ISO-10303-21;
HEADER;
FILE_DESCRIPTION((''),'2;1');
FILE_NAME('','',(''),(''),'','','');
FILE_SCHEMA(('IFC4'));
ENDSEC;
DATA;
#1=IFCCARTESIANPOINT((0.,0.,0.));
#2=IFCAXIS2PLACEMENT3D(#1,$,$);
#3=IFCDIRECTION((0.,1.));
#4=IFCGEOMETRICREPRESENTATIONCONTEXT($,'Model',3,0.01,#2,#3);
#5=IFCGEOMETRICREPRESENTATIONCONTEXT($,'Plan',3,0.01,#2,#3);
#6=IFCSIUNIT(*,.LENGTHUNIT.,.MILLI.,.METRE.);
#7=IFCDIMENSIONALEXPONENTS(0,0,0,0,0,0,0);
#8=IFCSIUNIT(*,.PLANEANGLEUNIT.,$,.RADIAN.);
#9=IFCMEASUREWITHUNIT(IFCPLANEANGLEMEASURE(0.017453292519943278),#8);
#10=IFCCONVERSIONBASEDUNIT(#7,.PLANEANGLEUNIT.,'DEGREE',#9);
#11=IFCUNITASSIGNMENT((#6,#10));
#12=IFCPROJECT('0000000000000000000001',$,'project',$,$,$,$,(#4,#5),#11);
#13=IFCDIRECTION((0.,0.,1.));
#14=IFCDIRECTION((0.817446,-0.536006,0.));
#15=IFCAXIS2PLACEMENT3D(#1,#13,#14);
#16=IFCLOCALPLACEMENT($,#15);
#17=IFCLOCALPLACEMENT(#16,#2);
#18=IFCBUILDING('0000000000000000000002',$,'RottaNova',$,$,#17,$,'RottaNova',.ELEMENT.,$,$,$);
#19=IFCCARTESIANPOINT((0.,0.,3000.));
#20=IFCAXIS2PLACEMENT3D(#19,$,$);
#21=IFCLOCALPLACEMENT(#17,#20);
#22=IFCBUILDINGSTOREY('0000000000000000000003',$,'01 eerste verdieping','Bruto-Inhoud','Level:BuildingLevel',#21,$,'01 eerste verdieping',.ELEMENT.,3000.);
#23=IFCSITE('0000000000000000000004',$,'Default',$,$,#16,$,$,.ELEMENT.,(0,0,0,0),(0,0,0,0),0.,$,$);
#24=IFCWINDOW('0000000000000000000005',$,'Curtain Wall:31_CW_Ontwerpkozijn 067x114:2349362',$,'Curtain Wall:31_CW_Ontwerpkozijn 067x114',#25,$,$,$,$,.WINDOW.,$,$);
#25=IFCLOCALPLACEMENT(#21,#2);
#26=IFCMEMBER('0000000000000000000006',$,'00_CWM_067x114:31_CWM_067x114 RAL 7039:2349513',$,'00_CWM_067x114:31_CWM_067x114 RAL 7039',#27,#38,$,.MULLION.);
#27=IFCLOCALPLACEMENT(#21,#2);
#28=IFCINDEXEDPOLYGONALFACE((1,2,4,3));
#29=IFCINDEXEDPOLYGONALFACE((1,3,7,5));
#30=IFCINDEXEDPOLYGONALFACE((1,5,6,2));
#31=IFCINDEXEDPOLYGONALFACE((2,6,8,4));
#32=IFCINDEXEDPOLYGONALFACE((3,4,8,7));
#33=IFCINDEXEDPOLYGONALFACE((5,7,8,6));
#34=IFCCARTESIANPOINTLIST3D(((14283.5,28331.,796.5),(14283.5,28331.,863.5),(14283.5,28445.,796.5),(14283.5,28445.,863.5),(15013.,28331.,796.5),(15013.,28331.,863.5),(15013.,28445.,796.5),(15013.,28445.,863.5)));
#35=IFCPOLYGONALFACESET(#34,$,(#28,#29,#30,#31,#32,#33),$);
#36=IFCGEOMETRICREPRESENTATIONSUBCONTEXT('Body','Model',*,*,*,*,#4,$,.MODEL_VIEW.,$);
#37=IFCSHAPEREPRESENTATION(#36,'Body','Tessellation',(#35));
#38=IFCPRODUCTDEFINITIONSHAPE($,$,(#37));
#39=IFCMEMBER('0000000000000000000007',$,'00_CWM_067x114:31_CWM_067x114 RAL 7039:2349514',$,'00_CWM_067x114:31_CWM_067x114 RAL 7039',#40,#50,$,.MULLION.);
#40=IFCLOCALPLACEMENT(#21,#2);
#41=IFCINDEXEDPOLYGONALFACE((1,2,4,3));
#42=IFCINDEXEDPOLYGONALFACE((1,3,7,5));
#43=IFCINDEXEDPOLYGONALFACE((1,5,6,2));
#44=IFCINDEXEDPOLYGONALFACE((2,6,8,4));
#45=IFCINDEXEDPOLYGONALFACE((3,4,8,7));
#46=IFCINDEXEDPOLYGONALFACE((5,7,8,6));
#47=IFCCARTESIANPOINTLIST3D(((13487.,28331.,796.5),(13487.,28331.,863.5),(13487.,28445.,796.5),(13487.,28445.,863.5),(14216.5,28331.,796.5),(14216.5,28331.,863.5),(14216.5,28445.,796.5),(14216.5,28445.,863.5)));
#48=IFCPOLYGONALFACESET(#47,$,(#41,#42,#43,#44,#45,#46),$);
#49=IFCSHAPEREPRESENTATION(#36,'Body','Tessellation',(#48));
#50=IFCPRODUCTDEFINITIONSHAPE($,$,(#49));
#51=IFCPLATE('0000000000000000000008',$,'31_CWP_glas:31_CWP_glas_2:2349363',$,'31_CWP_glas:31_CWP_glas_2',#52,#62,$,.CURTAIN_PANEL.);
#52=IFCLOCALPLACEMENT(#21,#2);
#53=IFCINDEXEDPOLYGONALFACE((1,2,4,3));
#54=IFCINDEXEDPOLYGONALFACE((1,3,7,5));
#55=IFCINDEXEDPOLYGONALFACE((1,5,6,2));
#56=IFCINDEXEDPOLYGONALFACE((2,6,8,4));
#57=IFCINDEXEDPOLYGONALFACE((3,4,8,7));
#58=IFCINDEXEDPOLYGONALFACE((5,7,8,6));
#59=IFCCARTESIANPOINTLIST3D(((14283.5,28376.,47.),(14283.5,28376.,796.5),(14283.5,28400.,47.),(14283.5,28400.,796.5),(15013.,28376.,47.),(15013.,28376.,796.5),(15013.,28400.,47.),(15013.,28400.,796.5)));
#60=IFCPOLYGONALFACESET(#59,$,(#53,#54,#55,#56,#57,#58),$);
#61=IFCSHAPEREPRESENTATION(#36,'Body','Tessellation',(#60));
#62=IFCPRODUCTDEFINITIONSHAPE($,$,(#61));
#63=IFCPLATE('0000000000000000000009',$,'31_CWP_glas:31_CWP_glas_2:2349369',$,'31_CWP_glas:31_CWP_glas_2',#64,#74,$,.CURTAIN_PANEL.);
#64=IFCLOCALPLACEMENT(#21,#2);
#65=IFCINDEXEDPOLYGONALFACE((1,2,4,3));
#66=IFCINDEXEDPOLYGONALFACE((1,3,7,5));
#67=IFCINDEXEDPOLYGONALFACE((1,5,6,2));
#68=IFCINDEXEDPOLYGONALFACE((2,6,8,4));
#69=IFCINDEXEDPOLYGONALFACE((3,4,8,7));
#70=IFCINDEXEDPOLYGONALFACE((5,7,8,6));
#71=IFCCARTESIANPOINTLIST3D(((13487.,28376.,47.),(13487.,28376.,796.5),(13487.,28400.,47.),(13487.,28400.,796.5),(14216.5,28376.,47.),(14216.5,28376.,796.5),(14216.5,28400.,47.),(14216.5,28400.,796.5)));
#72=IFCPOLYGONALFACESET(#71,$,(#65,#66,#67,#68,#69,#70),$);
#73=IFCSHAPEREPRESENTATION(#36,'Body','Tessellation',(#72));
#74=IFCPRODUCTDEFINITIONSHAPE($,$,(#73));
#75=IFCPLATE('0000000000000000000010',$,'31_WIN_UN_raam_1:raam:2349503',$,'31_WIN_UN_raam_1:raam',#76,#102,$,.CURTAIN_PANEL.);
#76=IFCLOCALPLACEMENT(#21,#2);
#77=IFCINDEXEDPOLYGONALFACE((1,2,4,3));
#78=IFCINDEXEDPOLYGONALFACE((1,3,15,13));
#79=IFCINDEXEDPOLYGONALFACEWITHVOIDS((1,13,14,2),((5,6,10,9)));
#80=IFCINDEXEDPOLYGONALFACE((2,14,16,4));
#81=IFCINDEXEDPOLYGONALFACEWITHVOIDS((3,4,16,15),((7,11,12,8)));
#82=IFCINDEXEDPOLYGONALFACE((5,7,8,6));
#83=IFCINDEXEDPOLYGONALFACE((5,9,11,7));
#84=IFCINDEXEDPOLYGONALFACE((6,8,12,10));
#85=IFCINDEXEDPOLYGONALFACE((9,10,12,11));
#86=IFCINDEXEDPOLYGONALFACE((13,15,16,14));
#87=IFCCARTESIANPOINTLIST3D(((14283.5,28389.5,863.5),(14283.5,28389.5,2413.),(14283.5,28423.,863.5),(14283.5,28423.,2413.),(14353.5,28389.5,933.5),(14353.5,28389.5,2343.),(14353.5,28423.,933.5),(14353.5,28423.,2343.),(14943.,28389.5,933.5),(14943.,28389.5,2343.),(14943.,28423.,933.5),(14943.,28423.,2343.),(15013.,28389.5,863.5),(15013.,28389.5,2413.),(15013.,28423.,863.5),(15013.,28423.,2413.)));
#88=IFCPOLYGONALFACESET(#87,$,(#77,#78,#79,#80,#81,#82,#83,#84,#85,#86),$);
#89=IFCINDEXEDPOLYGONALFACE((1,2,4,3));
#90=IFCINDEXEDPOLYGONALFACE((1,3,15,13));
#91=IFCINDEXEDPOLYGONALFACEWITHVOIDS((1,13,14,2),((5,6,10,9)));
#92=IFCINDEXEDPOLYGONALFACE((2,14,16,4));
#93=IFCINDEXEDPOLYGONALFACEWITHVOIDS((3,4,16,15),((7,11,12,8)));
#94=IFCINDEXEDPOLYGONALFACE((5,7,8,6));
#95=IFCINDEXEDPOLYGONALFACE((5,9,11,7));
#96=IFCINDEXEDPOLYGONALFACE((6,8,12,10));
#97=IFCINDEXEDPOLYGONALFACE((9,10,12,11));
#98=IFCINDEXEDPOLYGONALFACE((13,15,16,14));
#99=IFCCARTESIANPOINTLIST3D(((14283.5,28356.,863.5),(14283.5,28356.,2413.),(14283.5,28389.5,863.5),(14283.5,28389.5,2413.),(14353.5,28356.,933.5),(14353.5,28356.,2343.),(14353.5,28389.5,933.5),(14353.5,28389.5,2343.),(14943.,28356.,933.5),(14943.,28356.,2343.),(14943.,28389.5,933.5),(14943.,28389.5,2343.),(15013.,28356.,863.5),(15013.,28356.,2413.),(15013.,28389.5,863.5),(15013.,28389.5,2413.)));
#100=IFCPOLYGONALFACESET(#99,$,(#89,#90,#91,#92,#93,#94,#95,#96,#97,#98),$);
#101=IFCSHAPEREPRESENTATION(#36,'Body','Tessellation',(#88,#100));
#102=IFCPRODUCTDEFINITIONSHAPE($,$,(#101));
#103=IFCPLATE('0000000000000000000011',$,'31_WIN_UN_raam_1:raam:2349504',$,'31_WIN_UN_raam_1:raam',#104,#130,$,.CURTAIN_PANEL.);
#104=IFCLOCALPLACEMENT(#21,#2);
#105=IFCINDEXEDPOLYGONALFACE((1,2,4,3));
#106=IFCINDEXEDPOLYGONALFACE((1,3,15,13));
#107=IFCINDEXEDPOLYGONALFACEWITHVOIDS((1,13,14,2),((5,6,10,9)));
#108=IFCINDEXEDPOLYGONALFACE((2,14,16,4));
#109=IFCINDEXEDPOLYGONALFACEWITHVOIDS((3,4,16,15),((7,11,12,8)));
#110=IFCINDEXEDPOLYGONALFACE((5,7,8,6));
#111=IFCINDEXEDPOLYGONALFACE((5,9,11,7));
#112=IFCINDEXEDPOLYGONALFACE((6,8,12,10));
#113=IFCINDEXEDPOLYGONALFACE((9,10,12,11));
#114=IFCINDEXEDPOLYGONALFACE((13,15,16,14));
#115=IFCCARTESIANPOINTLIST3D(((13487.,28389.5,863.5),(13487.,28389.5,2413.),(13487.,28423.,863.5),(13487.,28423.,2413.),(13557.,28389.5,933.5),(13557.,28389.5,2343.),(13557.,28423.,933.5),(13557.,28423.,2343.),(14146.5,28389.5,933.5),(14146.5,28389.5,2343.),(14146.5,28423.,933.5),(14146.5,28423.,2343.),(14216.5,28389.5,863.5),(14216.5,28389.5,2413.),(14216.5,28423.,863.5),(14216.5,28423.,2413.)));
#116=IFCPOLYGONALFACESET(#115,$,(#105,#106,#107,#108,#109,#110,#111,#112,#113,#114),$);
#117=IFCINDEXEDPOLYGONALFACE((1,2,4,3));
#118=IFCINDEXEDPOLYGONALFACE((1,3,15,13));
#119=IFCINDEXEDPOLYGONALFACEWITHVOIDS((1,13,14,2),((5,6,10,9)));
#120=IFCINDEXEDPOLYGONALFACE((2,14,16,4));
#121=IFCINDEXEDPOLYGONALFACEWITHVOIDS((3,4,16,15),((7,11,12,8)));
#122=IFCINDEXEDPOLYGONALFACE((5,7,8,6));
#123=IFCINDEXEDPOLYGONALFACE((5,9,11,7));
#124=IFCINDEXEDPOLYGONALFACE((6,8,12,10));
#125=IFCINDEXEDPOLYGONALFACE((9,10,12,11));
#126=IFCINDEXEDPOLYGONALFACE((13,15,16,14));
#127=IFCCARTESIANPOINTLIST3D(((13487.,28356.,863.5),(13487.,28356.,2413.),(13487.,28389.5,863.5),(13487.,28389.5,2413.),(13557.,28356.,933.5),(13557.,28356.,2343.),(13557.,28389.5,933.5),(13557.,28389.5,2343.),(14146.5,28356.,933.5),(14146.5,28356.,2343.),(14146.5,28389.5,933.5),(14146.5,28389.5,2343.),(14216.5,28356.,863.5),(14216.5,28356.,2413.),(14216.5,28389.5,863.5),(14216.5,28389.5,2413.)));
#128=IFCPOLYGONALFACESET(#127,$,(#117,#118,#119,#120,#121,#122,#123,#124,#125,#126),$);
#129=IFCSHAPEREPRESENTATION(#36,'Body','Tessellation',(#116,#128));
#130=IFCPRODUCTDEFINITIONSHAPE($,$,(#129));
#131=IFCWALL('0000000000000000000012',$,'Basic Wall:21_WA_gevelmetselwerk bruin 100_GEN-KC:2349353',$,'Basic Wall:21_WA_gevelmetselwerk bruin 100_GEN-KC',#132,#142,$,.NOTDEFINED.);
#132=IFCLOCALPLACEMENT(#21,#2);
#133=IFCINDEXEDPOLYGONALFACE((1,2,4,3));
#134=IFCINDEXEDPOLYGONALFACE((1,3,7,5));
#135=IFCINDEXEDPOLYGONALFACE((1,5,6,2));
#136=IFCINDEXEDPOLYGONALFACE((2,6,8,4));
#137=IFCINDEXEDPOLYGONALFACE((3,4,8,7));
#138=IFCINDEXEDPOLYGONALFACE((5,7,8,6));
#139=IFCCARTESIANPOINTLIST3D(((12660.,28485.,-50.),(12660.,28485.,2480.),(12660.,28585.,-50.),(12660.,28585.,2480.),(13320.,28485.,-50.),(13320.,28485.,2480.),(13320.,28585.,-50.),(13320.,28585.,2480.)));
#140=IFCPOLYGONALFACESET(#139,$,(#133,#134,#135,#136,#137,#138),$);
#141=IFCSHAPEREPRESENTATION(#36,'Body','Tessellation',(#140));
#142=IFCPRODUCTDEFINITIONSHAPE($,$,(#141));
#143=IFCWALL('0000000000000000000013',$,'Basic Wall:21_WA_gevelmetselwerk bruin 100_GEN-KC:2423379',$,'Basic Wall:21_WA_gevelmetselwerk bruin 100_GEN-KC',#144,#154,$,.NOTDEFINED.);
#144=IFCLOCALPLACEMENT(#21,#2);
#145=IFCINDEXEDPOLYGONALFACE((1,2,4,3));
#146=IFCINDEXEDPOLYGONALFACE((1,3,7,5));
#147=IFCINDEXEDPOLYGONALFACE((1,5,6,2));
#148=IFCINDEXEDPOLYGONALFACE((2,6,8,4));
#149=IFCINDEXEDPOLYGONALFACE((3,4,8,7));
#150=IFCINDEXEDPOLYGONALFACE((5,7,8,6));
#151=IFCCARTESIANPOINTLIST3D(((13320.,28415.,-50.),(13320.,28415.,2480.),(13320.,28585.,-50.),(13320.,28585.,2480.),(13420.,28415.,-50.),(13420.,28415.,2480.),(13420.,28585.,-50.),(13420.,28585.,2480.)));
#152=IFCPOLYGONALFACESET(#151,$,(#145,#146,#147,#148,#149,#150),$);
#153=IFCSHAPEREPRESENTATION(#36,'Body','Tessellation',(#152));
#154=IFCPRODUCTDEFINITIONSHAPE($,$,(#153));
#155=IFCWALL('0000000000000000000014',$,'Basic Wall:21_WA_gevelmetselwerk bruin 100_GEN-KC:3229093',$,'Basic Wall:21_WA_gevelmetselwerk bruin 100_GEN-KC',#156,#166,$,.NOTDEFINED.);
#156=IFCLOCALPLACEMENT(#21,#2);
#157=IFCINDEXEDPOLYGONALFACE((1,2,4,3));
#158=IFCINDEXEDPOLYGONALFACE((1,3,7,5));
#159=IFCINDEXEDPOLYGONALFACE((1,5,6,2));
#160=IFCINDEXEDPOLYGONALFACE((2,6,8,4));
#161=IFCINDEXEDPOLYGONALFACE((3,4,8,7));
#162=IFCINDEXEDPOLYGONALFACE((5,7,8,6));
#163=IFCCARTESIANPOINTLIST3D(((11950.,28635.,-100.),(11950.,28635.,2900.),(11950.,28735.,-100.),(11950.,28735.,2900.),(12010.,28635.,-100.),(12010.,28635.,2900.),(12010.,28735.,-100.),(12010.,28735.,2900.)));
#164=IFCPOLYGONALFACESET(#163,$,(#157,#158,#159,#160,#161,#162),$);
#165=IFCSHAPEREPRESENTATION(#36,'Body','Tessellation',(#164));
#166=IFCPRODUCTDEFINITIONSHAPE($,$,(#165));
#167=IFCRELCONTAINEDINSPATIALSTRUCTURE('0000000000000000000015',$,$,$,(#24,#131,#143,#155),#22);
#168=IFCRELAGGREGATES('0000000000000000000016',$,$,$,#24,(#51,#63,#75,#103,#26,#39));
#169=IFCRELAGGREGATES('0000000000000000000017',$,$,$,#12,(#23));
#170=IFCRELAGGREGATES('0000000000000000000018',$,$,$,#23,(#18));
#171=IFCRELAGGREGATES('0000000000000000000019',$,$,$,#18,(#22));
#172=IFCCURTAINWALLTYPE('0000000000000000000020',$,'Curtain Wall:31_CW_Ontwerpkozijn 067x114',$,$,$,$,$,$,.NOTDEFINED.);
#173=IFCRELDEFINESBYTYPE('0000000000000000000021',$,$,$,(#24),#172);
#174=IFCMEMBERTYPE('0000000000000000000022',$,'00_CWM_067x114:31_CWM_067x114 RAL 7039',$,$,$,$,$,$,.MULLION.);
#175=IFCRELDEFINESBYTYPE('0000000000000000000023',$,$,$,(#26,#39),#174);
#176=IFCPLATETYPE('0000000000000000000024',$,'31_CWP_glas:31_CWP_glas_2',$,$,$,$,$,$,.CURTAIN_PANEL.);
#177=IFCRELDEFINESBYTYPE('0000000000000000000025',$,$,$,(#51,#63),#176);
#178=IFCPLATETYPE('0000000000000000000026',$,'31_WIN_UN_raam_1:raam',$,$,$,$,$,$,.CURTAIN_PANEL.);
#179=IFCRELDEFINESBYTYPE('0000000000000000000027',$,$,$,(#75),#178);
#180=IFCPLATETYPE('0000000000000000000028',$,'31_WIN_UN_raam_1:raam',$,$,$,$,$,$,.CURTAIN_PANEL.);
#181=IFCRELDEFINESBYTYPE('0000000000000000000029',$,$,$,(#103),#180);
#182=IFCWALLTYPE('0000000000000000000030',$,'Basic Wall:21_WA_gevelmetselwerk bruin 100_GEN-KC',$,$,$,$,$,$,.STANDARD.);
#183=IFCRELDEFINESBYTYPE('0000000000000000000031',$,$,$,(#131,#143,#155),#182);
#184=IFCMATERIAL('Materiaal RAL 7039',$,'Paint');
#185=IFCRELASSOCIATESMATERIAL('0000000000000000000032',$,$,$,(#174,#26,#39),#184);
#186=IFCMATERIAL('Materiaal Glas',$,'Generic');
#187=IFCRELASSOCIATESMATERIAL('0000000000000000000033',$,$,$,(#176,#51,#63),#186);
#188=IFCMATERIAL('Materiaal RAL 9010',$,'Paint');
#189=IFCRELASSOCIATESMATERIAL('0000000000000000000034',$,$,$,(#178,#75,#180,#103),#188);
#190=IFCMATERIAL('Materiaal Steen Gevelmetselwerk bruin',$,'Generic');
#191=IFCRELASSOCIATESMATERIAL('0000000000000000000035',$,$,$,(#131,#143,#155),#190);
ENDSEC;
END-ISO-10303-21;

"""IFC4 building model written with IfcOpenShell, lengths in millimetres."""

from ifc_helpers import new_model, entity, si_unit, converted_unit, direction, frame, origin, place, context, subcontext, project, spatial, indexed_curve, outline, extrude, source, transform, mapped, material, type_object, type_shapes, element, aggregate, save


model = new_model("IFC4")

# Units and contexts
model_context = context("Model", 3, precision=0.01, world=origin(), true_north=direction((0.0, 1.0)))
plan_context = context("Plan", 3, precision=0.01, world=origin(), true_north=direction((0.0, 1.0)))
body_context = subcontext(model_context, "Body", "Model", "MODEL_VIEW")
ifc_project = project(units=[si_unit("LENGTHUNIT", "METRE", prefix="MILLI"), converted_unit("PLANEANGLEUNIT", "DEGREE", entity("IfcPlaneAngleMeasure", 0.017453292519943278), si_unit("PLANEANGLEUNIT", "RADIAN"), dimensions=[0, 0, 0, 0, 0, 0, 0])], contexts=[model_context, plan_context])

# Site, building, storey
site_placement = place(None, frame((0.0, 0.0, 0.0), z_axis=(0.0, 0.0, 1.0), x_axis=(0.817446, -0.536006, 0.0)))
site = spatial("IfcSite", under=ifc_project, at=site_placement, Name="Default", CompositionType="ELEMENT", RefLatitude=(0, 0, 0, 0), RefLongitude=(0, 0, 0, 0), RefElevation=0.0)
building_placement = place(site_placement, origin())
building = spatial("IfcBuilding", under=site, at=building_placement, Name="RottaNova", LongName="RottaNova", CompositionType="ELEMENT")
storey_placement = place(building_placement, frame((0.0, 0.0, 3000.0)))
storey = spatial("IfcBuildingStorey", under=building, at=storey_placement, Name="01 eerste verdieping", Description="Bruto-Inhoud", ObjectType="Level:BuildingLevel", LongName="01 eerste verdieping", CompositionType="ELEMENT", Elevation=3000.0)

# Window, members, plates
curtain_wall_type = type_object("IfcCurtainWallType", Name="Curtain Wall:31_CW_Ontwerpkozijn 067x114", PredefinedType="NOTDEFINED")
window_placement = place(storey_placement, frame((0.0, 0.0, -3000.0)))
window = element("IfcWindow", 1, at=window_placement, inside=storey, type_object=curtain_wall_type, Name="Curtain Wall:31_CW_Ontwerpkozijn 067x114:2349362", ObjectType="Curtain Wall:31_CW_Ontwerpkozijn 067x114", PredefinedType="WINDOW")
ifc_material_1 = material(Name="Materiaal RAL 7039", Category="Paint")
member_type_1 = type_object("IfcMemberType", Name="00_CWM_067x114:31_CWM_067x114 RAL 7039", PredefinedType="MULLION", material=ifc_material_1)
shared_shape_1 = source(origin(), body_context, "Body", "SweptSolid", [
    extrude(outline(indexed_curve([(-33.5, -57.0), (33.5, -57.0), (33.5, 57.0), (-33.5, 57.0), (-33.5, -57.0)], self_intersect=False)), frame((0.0, 57.0, -729.5), z_axis=(0.0, 0.0, 1.0), x_axis=(-1.0, 0.0, 0.0)), (0.0, 0.0, 1.0), 729.5),
])
type_shapes(member_type_1, [shared_shape_1])
member_1_placement = place(window_placement, frame((14283.5, 28331.0, 3830.0), z_axis=(-1.0, 0.0, 0.0), x_axis=(0.0, 0.0, 1.0)))
member_1 = element("IfcMember", 2, at=member_1_placement, type_object=member_type_1, material=ifc_material_1, Name="00_CWM_067x114:31_CWM_067x114 RAL 7039:2349513", ObjectType="00_CWM_067x114:31_CWM_067x114 RAL 7039", PredefinedType="MULLION", context=body_context, shape_type="MappedRepresentation", body=[
    mapped(shared_shape_1, transform((0.0, 0.0, 0.0), scale=1.0)),
])
member_2_placement = place(window_placement, frame((13487.0, 28331.0, 3830.0), z_axis=(-1.0, 0.0, 0.0), x_axis=(0.0, 0.0, 1.0)))
member_2 = element("IfcMember", 3, at=member_2_placement, type_object=member_type_1, material=ifc_material_1, Name="00_CWM_067x114:31_CWM_067x114 RAL 7039:2349514", ObjectType="00_CWM_067x114:31_CWM_067x114 RAL 7039", PredefinedType="MULLION", context=body_context, shape_type="MappedRepresentation", body=[
    mapped(shared_shape_1, transform((0.0, 0.0, 0.0), scale=1.0)),
])
ifc_material_2 = material(Name="Materiaal Glas", Category="Generic")
plate_type_1 = type_object("IfcPlateType", Name="31_CWP_glas:31_CWP_glas_2", PredefinedType="CURTAIN_PANEL", material=ifc_material_2)
shared_shape_2 = source(origin(), body_context, "Body", "SweptSolid", [
    extrude(outline(indexed_curve([(-12.0, -364.7), (12.0, -364.7), (12.0, 364.7), (-12.0, 364.7), (-12.0, -364.7)], self_intersect=False)), frame((0.0, -57.0, 0.0), z_axis=(0.0, 0.0, 1.0), x_axis=(0.0, 1.0, 0.0)), (0.0, 0.0, 1.0), 749.5),
])
type_shapes(plate_type_1, [shared_shape_2])
plate_1_placement = place(window_placement, frame((14648.3, 28331.0, 3047.0), z_axis=(0.0, 0.0, 1.0), x_axis=(-1.0, 0.0, 0.0)))
plate_1 = element("IfcPlate", 4, at=plate_1_placement, type_object=plate_type_1, material=ifc_material_2, Name="31_CWP_glas:31_CWP_glas_2:2349363", ObjectType="31_CWP_glas:31_CWP_glas_2", PredefinedType="CURTAIN_PANEL", context=body_context, shape_type="MappedRepresentation", body=[
    mapped(shared_shape_2, transform((0.0, 0.0, 0.0), scale=1.0)),
])
plate_2_placement = place(window_placement, frame((13851.8, 28331.0, 3047.0), z_axis=(0.0, 0.0, 1.0), x_axis=(-1.0, 0.0, 0.0)))
plate_2 = element("IfcPlate", 5, at=plate_2_placement, type_object=plate_type_1, material=ifc_material_2, Name="31_CWP_glas:31_CWP_glas_2:2349369", ObjectType="31_CWP_glas:31_CWP_glas_2", PredefinedType="CURTAIN_PANEL", context=body_context, shape_type="MappedRepresentation", body=[
    mapped(shared_shape_2, transform((0.0, 0.0, 0.0), scale=1.0)),
])
ifc_material_3 = material(Name="Materiaal RAL 9010", Category="Paint")
plate_type_2 = type_object("IfcPlateType", Name="31_WIN_UN_raam_1:raam", PredefinedType="CURTAIN_PANEL", material=ifc_material_3)
shared_shape_3 = source(origin(), body_context, "Body", "SweptSolid", [
    extrude(outline(indexed_curve([(-364.7, -774.7), (364.7, -774.7), (364.7, 774.7), (-364.7, 774.7), (-364.7, -774.7)], self_intersect=False), holes=[indexed_curve([(-294.7, 704.7), (294.7, 704.7), (294.7, -704.8), (-294.7, -704.8), (-294.7, 704.7)], self_intersect=False)]), frame((0.0, -92.0, 774.8), z_axis=(0.0, 1.0, 0.0), x_axis=(1.0, 0.0, 0.0)), (0.0, 0.0, 1.0), 33.5),
    extrude(outline(indexed_curve([(-364.7, -774.7), (364.7, -774.7), (364.7, 774.7), (-364.7, 774.7), (-364.7, -774.7)], self_intersect=False), holes=[indexed_curve([(-294.7, 704.7), (294.7, 704.7), (294.7, -704.8), (-294.7, -704.8), (-294.7, 704.7)], self_intersect=False)]), frame((0.0, -58.5, 774.8), z_axis=(0.0, 1.0, 0.0), x_axis=(1.0, 0.0, 0.0)), (0.0, 0.0, 1.0), 33.5),
])
type_shapes(plate_type_2, [shared_shape_3])
plate_3_placement = place(window_placement, frame((14648.3, 28331.0, 3863.5), z_axis=(0.0, 0.0, 1.0), x_axis=(-1.0, 0.0, 0.0)))
plate_3 = element("IfcPlate", 6, at=plate_3_placement, type_object=plate_type_2, material=ifc_material_3, Name="31_WIN_UN_raam_1:raam:2349503", ObjectType="31_WIN_UN_raam_1:raam", PredefinedType="CURTAIN_PANEL", context=body_context, shape_type="MappedRepresentation", body=[
    mapped(shared_shape_3, transform((0.0, 0.0, 0.0), scale=1.0)),
])
plate_type_3 = type_object("IfcPlateType", Name="31_WIN_UN_raam_1:raam", PredefinedType="CURTAIN_PANEL", material=ifc_material_3)
shared_shape_4 = source(origin(), body_context, "Body", "SweptSolid", [
    extrude(outline(indexed_curve([(-364.7, -774.7), (364.7, -774.7), (364.7, 774.7), (-364.7, 774.7), (-364.7, -774.7)], self_intersect=False), holes=[indexed_curve([(-294.7, 704.7), (294.7, 704.7), (294.7, -704.8), (-294.7, -704.8), (-294.7, 704.7)], self_intersect=False)]), frame((0.0, -92.0, 774.8), z_axis=(0.0, 1.0, 0.0), x_axis=(1.0, 0.0, 0.0)), (0.0, 0.0, 1.0), 33.5),
    extrude(outline(indexed_curve([(-364.7, -774.7), (364.7, -774.7), (364.7, 774.7), (-364.7, 774.7), (-364.7, -774.7)], self_intersect=False), holes=[indexed_curve([(-294.7, 704.7), (294.7, 704.7), (294.7, -704.8), (-294.7, -704.8), (-294.7, 704.7)], self_intersect=False)]), frame((0.0, -58.5, 774.8), z_axis=(0.0, 1.0, 0.0), x_axis=(1.0, 0.0, 0.0)), (0.0, 0.0, 1.0), 33.5),
])
type_shapes(plate_type_3, [shared_shape_4])
plate_4_placement = place(window_placement, frame((13851.8, 28331.0, 3863.5), z_axis=(0.0, 0.0, 1.0), x_axis=(-1.0, 0.0, 0.0)))
plate_4 = element("IfcPlate", 7, at=plate_4_placement, type_object=plate_type_3, material=ifc_material_3, Name="31_WIN_UN_raam_1:raam:2349504", ObjectType="31_WIN_UN_raam_1:raam", PredefinedType="CURTAIN_PANEL", context=body_context, shape_type="MappedRepresentation", body=[
    mapped(shared_shape_4, transform((0.0, 0.0, 0.0), scale=1.0)),
])
aggregate(window, [plate_1, plate_2, plate_3, plate_4, member_1, member_2])

# Walls
ifc_material_4 = material(Name="Materiaal Steen Gevelmetselwerk bruin", Category="Generic")
wall_type = type_object("IfcWallType", Name="Basic Wall:21_WA_gevelmetselwerk bruin 100_GEN-KC", PredefinedType="STANDARD")
wall_1_placement = place(storey_placement, frame((12660.0, 28535.0, -50.0)))
element("IfcWall", 8, at=wall_1_placement, inside=storey, type_object=wall_type, material=ifc_material_4, Name="Basic Wall:21_WA_gevelmetselwerk bruin 100_GEN-KC:2349353", ObjectType="Basic Wall:21_WA_gevelmetselwerk bruin 100_GEN-KC", PredefinedType="NOTDEFINED", context=body_context, shape_type="SweptSolid", body=[
    extrude(outline(indexed_curve([(660.0, 50.0), (0.0, 50.0), (0.0, -50.0), (660.0, -50.0), (660.0, 50.0)], self_intersect=False)), origin(), (0.0, 0.0, 1.0), 2530.0),
])
wall_2_placement = place(storey_placement, frame((13370.0, 28415.0, -50.0), z_axis=(0.0, 0.0, 1.0), x_axis=(0.0, 1.0, 0.0)))
element("IfcWall", 9, at=wall_2_placement, inside=storey, type_object=wall_type, material=ifc_material_4, Name="Basic Wall:21_WA_gevelmetselwerk bruin 100_GEN-KC:2423379", ObjectType="Basic Wall:21_WA_gevelmetselwerk bruin 100_GEN-KC", PredefinedType="NOTDEFINED", context=body_context, shape_type="SweptSolid", body=[
    extrude(outline(indexed_curve([(170.0, 50.0), (0.0, 50.0), (0.0, -50.0), (170.0, -50.0), (170.0, 50.0)], self_intersect=False)), origin(), (0.0, 0.0, 1.0), 2530.0),
])
wall_3_placement = place(storey_placement, frame((12010.0, 28685.0, -100.0), z_axis=(0.0, 0.0, 1.0), x_axis=(-1.0, 0.0, 0.0)))
element("IfcWall", 10, at=wall_3_placement, inside=storey, type_object=wall_type, material=ifc_material_4, Name="Basic Wall:21_WA_gevelmetselwerk bruin 100_GEN-KC:3229093", ObjectType="Basic Wall:21_WA_gevelmetselwerk bruin 100_GEN-KC", PredefinedType="NOTDEFINED", context=body_context, shape_type="SweptSolid", body=[
    extrude(outline(indexed_curve([(60.0, 50.0), (0.0, 50.0), (0.0, -50.0), (60.0, -50.0), (60.0, 50.0)], self_intersect=False)), origin(), (0.0, 0.0, 1.0), 3000.0),
])

save(model, "model.ifc")
